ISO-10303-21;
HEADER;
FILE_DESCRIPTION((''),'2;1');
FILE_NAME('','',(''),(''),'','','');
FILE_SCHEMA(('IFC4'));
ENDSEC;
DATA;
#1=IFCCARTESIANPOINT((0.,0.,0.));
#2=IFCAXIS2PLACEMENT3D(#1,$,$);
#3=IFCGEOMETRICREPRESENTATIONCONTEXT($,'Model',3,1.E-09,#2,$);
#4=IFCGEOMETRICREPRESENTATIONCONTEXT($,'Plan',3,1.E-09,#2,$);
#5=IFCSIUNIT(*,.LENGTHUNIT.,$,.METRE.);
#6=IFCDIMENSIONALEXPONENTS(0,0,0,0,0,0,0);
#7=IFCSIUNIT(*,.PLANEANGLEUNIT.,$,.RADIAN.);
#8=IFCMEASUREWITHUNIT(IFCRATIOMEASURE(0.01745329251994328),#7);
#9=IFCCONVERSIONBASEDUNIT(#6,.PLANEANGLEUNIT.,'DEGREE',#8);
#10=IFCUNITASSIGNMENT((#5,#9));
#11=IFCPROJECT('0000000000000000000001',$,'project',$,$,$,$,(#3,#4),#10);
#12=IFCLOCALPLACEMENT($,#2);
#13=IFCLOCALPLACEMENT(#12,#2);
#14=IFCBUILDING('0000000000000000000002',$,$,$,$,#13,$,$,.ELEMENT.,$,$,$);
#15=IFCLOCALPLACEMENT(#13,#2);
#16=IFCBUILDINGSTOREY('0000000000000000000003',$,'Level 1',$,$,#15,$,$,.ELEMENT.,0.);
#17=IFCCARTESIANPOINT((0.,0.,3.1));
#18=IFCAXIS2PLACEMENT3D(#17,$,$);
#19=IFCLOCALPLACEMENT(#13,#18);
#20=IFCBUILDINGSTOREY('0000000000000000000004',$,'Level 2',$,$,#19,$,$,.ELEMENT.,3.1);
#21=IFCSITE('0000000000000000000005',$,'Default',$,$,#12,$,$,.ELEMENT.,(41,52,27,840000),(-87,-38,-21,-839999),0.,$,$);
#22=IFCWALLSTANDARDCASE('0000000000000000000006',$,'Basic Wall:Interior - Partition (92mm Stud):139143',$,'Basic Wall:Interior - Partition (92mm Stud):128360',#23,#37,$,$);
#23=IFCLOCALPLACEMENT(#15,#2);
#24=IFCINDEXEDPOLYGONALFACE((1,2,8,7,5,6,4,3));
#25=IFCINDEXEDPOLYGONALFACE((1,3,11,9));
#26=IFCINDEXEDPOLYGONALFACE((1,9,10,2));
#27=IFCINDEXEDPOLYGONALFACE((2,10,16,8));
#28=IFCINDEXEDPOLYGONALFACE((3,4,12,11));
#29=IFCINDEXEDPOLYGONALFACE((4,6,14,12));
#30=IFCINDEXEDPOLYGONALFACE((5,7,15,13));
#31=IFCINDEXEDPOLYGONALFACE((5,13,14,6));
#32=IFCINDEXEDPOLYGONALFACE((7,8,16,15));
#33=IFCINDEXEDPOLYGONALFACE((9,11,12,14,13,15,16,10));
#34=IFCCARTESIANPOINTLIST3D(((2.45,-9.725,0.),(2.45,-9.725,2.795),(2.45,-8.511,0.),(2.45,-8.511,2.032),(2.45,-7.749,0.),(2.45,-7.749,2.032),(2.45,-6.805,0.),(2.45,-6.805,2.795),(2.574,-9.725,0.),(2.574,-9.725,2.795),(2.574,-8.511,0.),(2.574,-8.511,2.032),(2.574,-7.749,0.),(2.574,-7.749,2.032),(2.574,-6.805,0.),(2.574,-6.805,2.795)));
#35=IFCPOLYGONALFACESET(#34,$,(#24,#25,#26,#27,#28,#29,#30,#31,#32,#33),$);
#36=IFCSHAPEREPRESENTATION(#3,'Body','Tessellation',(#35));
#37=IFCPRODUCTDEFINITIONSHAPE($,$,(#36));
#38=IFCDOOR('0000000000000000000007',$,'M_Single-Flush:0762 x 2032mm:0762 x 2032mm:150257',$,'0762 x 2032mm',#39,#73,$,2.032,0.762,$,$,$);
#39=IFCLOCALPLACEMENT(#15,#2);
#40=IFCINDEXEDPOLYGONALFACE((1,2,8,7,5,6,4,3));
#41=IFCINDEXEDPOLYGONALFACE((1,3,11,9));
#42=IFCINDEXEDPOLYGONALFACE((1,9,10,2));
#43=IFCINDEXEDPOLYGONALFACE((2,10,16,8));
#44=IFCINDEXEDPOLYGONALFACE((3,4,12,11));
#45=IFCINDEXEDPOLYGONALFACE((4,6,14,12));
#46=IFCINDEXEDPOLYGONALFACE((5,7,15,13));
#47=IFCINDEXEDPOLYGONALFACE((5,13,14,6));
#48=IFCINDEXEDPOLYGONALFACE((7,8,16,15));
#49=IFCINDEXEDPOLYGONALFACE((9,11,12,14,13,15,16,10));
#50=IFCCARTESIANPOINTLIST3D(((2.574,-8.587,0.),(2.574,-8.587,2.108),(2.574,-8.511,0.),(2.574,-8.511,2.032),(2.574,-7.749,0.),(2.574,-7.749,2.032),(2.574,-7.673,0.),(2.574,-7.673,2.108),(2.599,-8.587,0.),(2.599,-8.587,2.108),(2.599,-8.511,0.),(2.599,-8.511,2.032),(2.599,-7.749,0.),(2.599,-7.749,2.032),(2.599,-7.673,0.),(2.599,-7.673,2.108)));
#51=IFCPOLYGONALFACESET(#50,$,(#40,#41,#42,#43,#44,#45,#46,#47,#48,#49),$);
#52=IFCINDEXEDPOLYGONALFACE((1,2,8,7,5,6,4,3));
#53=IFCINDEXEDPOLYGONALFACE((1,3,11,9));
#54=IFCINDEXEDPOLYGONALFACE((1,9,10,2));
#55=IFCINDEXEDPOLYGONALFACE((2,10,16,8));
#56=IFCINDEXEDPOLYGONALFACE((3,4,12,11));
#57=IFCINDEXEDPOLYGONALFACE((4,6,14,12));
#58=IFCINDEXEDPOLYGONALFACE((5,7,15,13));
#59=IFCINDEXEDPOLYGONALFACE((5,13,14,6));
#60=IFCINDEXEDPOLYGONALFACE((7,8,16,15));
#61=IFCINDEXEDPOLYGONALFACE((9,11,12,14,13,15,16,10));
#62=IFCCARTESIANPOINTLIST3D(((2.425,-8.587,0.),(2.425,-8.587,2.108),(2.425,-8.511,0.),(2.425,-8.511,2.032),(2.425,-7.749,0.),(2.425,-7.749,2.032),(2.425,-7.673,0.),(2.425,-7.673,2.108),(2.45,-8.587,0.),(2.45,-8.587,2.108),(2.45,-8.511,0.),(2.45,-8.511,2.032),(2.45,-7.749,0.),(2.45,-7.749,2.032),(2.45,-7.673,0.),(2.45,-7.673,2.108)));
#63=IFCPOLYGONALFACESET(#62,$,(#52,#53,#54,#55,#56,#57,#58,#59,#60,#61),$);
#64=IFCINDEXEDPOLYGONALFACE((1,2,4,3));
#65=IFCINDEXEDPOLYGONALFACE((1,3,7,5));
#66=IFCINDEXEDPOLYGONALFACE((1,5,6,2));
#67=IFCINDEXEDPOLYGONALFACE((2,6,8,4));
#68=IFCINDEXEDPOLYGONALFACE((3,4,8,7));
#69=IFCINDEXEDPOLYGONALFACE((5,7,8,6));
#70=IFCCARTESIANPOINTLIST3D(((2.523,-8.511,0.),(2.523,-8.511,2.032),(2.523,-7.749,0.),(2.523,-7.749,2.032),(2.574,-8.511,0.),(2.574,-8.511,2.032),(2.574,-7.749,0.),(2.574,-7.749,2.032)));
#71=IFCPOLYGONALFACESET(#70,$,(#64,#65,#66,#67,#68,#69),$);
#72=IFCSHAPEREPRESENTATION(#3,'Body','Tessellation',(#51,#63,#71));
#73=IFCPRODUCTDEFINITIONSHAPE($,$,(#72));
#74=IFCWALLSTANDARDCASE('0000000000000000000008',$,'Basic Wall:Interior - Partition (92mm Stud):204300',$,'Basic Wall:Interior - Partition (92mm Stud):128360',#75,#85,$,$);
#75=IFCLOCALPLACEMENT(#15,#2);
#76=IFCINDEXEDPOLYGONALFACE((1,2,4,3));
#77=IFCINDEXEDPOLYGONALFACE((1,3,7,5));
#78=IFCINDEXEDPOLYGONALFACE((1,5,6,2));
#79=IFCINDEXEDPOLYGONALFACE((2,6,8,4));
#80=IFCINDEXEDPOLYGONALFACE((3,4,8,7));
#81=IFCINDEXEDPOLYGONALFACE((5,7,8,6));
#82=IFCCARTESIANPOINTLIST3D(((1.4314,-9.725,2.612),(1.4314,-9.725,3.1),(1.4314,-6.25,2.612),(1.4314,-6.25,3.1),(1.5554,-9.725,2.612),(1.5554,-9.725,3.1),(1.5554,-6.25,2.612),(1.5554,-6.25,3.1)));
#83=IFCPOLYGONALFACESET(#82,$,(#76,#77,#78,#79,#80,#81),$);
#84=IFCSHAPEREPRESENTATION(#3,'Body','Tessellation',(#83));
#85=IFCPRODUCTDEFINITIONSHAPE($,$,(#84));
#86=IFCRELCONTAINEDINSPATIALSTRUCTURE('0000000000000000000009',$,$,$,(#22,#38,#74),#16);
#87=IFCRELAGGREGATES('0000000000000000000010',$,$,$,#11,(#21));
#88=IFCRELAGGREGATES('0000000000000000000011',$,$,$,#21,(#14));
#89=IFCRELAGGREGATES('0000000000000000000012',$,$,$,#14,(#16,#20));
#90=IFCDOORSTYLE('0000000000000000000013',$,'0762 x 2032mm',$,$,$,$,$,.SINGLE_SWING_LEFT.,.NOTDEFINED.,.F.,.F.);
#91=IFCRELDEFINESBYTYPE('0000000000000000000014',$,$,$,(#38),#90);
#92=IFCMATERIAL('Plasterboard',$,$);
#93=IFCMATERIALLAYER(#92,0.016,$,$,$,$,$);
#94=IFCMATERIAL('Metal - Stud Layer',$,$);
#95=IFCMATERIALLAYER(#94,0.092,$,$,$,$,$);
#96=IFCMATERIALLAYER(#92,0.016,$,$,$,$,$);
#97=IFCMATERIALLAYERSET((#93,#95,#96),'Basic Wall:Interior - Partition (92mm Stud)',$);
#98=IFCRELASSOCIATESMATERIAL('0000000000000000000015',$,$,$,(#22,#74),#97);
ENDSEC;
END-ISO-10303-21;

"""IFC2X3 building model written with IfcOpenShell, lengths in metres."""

from ifc_helpers import new_model, entity, si_unit, converted_unit, frame, frame_2d, origin, origin_2d_with_axis, place, context, project, spatial, polyline, rectangle, outline, extrude, source, transform, mapped, material, layer, layer_set, layer_usage, type_object, type_shapes, element, fill, save


model = new_model("IFC2X3")

# Units and contexts
model_context = context("Model", 3, precision=1e-09, world=origin())
plan_context = context("Plan", 3, precision=1e-09, world=origin())
ifc_project = project(units=[si_unit("LENGTHUNIT", "METRE"), converted_unit("PLANEANGLEUNIT", "DEGREE", entity("IfcRatioMeasure", 0.01745329251994328), si_unit("PLANEANGLEUNIT", "RADIAN"), dimensions=[0, 0, 0, 0, 0, 0, 0])], contexts=[model_context, plan_context])

# Site, building, storey
site_placement = place(None, origin())
site = spatial("IfcSite", under=ifc_project, at=site_placement, Name="Default", CompositionType="ELEMENT", RefLatitude=(41, 52, 27, 840000), RefLongitude=(-87, -38, -21, -839999), RefElevation=0.0)
building_placement = place(site_placement, origin())
building = spatial("IfcBuilding", under=site, at=building_placement, CompositionType="ELEMENT")
storey_1_placement = place(building_placement, origin())
storey_1 = spatial("IfcBuildingStorey", under=building, at=storey_1_placement, Name="Level 1", CompositionType="ELEMENT", Elevation=0.0)

# Shared definitions
ifc_material_1 = material(Name="Metal - Stud Layer")
ifc_material_2 = material(Name="Plasterboard")

# Wall, opening, door
ifc_layer_1 = layer(ifc_material_2, 0.016)
ifc_layer_2 = layer(ifc_material_1, 0.092)
ifc_layer_3 = layer(ifc_material_2, 0.016)
ifc_layer_set_1 = layer_set([ifc_layer_1, ifc_layer_2, ifc_layer_3], Name="Basic Wall:Interior - Partition (92mm Stud)")
ifc_layer_usage_1 = layer_usage(ifc_layer_set_1, "AXIS2", "NEGATIVE", 0.062)
wall_1_placement = place(storey_1_placement, frame((2.512, -6.805, 0.0), z_axis=(0.0, 0.0, 1.0), x_axis=(0.0, -1.0, 0.0)))
wall_1 = element("IfcWallStandardCase", 1, at=wall_1_placement, inside=storey_1, material=ifc_layer_usage_1, Name="Basic Wall:Interior - Partition (92mm Stud):139143", ObjectType="Basic Wall:Interior - Partition (92mm Stud):128360", context=model_context, shape_type="SweptSolid", body=[
    extrude(rectangle(XDim=2.92, YDim=0.124, at=frame_2d((1.46, 0.0), x_axis=(-1.0, 0.0))), origin(), (0.0, 0.0, 1.0), 2.795),
])
opening_1_placement = place(wall_1_placement, frame((0.944, -0.062, 0.0)))
opening_1 = element("IfcOpeningElement", 2, at=opening_1_placement, cuts=wall_1, ObjectType="Opening", context=model_context, shape_type="SweptSolid", body=[
    extrude(rectangle(XDim=0.762, YDim=2.032, at=frame_2d((1.016, 0.381), x_axis=(0.0, -1.0))), frame((0.0, 0.0, 0.0), z_axis=(0.0, 1.0, 0.0), x_axis=(0.0, 0.0, 1.0)), (0.0, 0.0, 1.0), 0.124),
])
door_style_1 = type_object("IfcDoorStyle", Name="0762 x 2032mm", ConstructionType="NOTDEFINED", OperationType="SINGLE_SWING_LEFT", ParameterTakesPrecedence=False, Sizeable=False)
shared_shape_1 = source(origin(), model_context, "Body", "SweptSolid", [
    extrude(outline(polyline([(-0.457, -1.073), (0.457, -1.073), (0.457, 1.035), (0.381, 1.035), (0.381, -0.997), (-0.381, -0.997), (-0.381, 1.035), (-0.457, 1.035), (-0.457, -1.073)])), frame((0.381, 0.149, 1.035), z_axis=(0.0, -1.0, 0.0), x_axis=(-1.0, 0.0, 0.0)), (0.0, 0.0, 1.0), 0.025),
    extrude(outline(polyline([(-1.073, -0.457), (1.035, -0.457), (1.035, -0.381), (-0.997, -0.381), (-0.997, 0.381), (1.035, 0.381), (1.035, 0.457), (-1.073, 0.457), (-1.073, -0.457)])), frame((0.381, 0.0, 1.035), z_axis=(0.0, -1.0, 0.0), x_axis=(0.0, 0.0, -1.0)), (0.0, 0.0, 1.0), 0.025),
    extrude(rectangle(XDim=0.762, YDim=0.051, at=origin_2d_with_axis()), frame((0.381, 0.0985, 0.0)), (0.0, 0.0, 1.0), 2.032),
])
type_shapes(door_style_1, [shared_shape_1])
door_1_placement = place(opening_1_placement, origin())
door_1 = element("IfcDoor", 3, at=door_1_placement, inside=storey_1, type_object=door_style_1, Name="M_Single-Flush:0762 x 2032mm:0762 x 2032mm:150257", ObjectType="0762 x 2032mm", OverallHeight=2.032, OverallWidth=0.762, context=model_context, shape_type="MappedRepresentation", body=[
    mapped(shared_shape_1, transform((0.0, 0.0, 0.0), scale=1.0)),
])
fill(opening_1, door_1)

# Shared definitions
storey_2_placement = place(building_placement, frame((0.0, 0.0, 3.1)))
storey_2 = spatial("IfcBuildingStorey", under=building, at=storey_2_placement, Name="Level 2", CompositionType="ELEMENT", Elevation=3.1)

# Wall
ifc_layer_usage_2 = layer_usage(ifc_layer_set_1, "AXIS2", "NEGATIVE", 0.062)
wall_2_placement = place(storey_1_placement, frame((1.4934, -6.25, 2.612), z_axis=(0.0, 0.0, 1.0), x_axis=(0.0, -1.0, 0.0)))
element("IfcWallStandardCase", 4, at=wall_2_placement, inside=storey_1, material=ifc_layer_usage_2, Name="Basic Wall:Interior - Partition (92mm Stud):204300", ObjectType="Basic Wall:Interior - Partition (92mm Stud):128360", context=model_context, shape_type="SweptSolid", body=[
    extrude(rectangle(XDim=3.475, YDim=0.124, at=frame_2d((1.7375, 0.0), x_axis=(-1.0, 0.0))), origin(), (0.0, 0.0, 1.0), 0.488),
])

save(model, "model.ifc")
